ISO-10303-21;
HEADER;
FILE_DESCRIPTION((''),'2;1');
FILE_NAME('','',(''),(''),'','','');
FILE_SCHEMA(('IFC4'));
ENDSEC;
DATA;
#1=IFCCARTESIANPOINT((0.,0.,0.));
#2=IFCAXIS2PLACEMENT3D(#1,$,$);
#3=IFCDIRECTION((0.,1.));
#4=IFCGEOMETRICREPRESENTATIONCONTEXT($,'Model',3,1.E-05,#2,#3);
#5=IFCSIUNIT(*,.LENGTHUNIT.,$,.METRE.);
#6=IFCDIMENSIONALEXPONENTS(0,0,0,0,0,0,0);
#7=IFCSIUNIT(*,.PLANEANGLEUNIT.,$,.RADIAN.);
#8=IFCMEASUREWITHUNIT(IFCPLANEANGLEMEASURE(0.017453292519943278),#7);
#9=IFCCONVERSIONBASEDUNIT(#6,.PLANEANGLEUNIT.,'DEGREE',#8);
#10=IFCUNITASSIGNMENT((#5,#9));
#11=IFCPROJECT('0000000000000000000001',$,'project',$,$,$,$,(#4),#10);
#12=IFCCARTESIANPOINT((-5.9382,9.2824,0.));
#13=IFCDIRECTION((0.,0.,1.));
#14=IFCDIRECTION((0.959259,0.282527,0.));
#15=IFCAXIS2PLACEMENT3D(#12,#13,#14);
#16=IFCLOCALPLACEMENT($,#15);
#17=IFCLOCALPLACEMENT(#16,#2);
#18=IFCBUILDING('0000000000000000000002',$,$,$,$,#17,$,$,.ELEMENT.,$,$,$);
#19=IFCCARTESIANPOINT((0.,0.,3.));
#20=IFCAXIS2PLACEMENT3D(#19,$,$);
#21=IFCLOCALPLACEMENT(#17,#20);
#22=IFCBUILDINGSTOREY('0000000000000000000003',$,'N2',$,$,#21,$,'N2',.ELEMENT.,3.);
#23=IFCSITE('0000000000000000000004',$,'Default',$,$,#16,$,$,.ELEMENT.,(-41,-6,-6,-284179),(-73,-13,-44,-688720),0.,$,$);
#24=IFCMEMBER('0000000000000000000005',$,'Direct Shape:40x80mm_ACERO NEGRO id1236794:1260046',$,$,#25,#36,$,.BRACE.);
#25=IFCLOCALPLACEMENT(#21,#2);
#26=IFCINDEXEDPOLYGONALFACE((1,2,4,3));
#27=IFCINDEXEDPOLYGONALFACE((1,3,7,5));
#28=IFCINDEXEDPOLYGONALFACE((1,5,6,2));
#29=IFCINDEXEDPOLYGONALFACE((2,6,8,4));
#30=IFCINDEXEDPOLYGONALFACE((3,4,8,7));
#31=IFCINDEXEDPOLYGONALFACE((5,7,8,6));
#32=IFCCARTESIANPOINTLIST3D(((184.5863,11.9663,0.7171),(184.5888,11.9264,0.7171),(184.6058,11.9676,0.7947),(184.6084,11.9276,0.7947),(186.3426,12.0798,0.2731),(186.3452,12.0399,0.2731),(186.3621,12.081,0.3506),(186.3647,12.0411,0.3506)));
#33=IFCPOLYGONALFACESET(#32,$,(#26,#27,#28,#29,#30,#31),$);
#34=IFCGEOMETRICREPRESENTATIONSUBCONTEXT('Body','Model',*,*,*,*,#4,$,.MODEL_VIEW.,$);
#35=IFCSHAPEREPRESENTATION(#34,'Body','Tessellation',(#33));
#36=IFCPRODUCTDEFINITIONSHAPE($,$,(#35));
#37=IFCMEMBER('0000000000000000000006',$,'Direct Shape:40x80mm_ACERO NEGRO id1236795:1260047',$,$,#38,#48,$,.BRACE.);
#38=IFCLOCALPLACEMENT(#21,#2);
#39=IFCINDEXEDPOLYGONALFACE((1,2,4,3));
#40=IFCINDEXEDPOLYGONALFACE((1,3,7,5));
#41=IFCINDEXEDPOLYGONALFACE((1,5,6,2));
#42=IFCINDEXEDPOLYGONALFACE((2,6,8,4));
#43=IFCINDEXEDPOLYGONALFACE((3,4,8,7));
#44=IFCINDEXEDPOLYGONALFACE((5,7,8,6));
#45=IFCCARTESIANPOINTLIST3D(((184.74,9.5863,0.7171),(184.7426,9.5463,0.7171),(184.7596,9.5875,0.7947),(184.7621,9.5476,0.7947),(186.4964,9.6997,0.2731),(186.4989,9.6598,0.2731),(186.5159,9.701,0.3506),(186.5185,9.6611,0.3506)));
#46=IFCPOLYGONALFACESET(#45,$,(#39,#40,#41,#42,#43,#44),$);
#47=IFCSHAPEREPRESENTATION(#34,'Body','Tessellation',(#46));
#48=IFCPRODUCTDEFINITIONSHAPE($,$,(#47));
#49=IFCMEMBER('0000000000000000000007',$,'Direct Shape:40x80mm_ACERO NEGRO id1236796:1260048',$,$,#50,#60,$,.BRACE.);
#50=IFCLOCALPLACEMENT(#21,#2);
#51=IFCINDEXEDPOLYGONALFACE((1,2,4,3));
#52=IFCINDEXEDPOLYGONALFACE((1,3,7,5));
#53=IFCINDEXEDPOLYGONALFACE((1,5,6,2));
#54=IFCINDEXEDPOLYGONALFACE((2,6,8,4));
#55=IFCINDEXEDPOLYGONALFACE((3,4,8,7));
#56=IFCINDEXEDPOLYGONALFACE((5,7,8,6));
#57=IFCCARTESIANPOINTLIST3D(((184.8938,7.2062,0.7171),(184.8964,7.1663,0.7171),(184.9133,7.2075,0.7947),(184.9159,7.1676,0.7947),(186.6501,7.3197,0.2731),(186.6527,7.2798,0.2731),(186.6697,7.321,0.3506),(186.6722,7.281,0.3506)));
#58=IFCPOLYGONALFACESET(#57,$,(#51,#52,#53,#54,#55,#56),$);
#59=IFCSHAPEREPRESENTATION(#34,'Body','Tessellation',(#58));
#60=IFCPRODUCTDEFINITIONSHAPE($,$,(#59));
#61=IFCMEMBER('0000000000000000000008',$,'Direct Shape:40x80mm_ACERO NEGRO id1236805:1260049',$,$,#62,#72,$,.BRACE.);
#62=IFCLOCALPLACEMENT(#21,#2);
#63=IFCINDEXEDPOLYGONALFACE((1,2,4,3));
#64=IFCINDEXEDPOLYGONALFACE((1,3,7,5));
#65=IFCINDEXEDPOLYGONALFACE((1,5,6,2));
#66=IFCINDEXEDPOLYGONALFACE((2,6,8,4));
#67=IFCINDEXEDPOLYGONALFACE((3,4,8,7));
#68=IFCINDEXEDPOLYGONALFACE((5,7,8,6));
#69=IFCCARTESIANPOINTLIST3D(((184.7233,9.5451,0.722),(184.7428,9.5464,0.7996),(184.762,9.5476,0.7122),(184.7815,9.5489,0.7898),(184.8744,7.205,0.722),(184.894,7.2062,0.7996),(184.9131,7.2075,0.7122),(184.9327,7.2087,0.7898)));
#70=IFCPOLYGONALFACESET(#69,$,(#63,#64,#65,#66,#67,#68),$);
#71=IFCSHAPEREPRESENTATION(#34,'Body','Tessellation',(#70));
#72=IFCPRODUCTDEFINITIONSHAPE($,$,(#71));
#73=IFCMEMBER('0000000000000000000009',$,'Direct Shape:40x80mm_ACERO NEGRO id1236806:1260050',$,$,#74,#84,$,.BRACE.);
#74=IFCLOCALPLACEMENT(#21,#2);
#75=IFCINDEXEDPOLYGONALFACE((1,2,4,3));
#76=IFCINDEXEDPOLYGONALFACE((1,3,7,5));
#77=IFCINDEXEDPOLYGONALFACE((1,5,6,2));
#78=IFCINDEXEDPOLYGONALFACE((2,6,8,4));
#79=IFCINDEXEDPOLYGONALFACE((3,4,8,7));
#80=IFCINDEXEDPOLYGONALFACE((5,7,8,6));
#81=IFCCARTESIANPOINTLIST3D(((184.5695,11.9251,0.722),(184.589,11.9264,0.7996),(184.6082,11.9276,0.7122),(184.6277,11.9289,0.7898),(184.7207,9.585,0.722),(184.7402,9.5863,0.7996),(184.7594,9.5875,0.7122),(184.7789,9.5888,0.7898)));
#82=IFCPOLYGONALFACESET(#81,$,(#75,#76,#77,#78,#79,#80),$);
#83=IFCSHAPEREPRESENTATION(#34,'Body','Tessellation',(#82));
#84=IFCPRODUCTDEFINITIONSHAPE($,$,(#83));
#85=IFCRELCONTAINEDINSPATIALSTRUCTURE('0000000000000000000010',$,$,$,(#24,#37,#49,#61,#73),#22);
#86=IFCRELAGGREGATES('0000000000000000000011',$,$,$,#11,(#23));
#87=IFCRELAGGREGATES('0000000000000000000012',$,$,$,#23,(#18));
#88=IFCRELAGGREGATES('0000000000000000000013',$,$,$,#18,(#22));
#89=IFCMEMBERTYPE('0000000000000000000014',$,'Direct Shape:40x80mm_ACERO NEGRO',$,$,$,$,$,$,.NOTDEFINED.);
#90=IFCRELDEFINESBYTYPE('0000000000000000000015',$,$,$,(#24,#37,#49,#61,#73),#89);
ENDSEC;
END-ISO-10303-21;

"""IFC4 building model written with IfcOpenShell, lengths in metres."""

from ifc_helpers import new_model, entity, si_unit, converted_unit, direction, frame, frame_2d, origin, place, context, subcontext, project, spatial, rectangle, extrude, type_object, element, save


model = new_model("IFC4")

# Units and contexts
model_context = context("Model", 3, precision=1e-05, world=origin(), true_north=direction((0.0, 1.0)))
body_context = subcontext(model_context, "Body", "Model", "MODEL_VIEW")
ifc_project = project(units=[si_unit("LENGTHUNIT", "METRE"), converted_unit("PLANEANGLEUNIT", "DEGREE", entity("IfcPlaneAngleMeasure", 0.017453292519943278), si_unit("PLANEANGLEUNIT", "RADIAN"), dimensions=[0, 0, 0, 0, 0, 0, 0])], contexts=[model_context])

# Site, building, storey
site_placement = place(None, frame((-5.9382, 9.2824, 0.0), z_axis=(0.0, 0.0, 1.0), x_axis=(0.959259, 0.282527, 0.0)))
site = spatial("IfcSite", under=ifc_project, at=site_placement, Name="Default", CompositionType="ELEMENT", RefLatitude=(-41, -6, -6, -284179), RefLongitude=(-73, -13, -44, -688720), RefElevation=0.0)
building_placement = place(site_placement, origin())
building = spatial("IfcBuilding", under=site, at=building_placement, CompositionType="ELEMENT")
storey_placement = place(building_placement, frame((0.0, 0.0, 3.0)))
storey = spatial("IfcBuildingStorey", under=building, at=storey_placement, Name="N2", LongName="N2", CompositionType="ELEMENT", Elevation=3.0)

# Members
member_type_1 = type_object("IfcMemberType", Name="Direct Shape:40x80mm_ACERO NEGRO", PredefinedType="NOTDEFINED")
member_1_placement = place(storey_placement, origin())
element("IfcMember", 1, at=member_1_placement, inside=storey, type_object=member_type_1, Name="Direct Shape:40x80mm_ACERO NEGRO id1236794:1260046", PredefinedType="BRACE", context=body_context, shape_type="SweptSolid", body=[
    extrude(rectangle(XDim=0.08, YDim=0.04, at=frame_2d((0.0, 0.0), x_axis=(1.0, 0.0))), frame((184.5973, 11.947, 0.7559), z_axis=(0.967595, 0.062512, -0.244649), x_axis=(-0.24414, -0.015773, -0.969612)), (0.0, 0.0, 1.0), 1.8152),
])
member_2_placement = place(storey_placement, origin())
element("IfcMember", 2, at=member_2_placement, inside=storey, type_object=member_type_1, Name="Direct Shape:40x80mm_ACERO NEGRO id1236795:1260047", PredefinedType="BRACE", context=body_context, shape_type="SweptSolid", body=[
    extrude(rectangle(XDim=0.08, YDim=0.04, at=frame_2d((0.0, 0.0), x_axis=(1.0, 0.0))), frame((184.7511, 9.5669, 0.7559), z_axis=(0.967595, 0.062512, -0.244649), x_axis=(-0.24414, -0.015773, -0.969612)), (0.0, 0.0, 1.0), 1.8152),
])
member_3_placement = place(storey_placement, origin())
element("IfcMember", 3, at=member_3_placement, inside=storey, type_object=member_type_1, Name="Direct Shape:40x80mm_ACERO NEGRO id1236796:1260048", PredefinedType="BRACE", context=body_context, shape_type="SweptSolid", body=[
    extrude(rectangle(XDim=0.08, YDim=0.04, at=frame_2d((0.0, 0.0), x_axis=(1.0, 0.0))), frame((184.9048, 7.1869, 0.7559), z_axis=(0.967595, 0.062512, -0.244649), x_axis=(-0.24414, -0.015773, -0.969612)), (0.0, 0.0, 1.0), 1.8152),
])
member_4_placement = place(storey_placement, origin())
element("IfcMember", 4, at=member_4_placement, inside=storey, type_object=member_type_1, Name="Direct Shape:40x80mm_ACERO NEGRO id1236805:1260049", PredefinedType="BRACE", context=body_context, shape_type="SweptSolid", body=[
    extrude(rectangle(XDim=0.08, YDim=0.04, at=frame_2d((0.0, 0.0), x_axis=(0.0, 1.0))), frame((184.9036, 7.2069, 0.7559), z_axis=(-0.064471, 0.99792, 0.0), x_axis=(0.967595, 0.062512, -0.244649)), (0.0, 0.0, 1.0), 2.345),
])
member_5_placement = place(storey_placement, origin())
element("IfcMember", 5, at=member_5_placement, inside=storey, type_object=member_type_1, Name="Direct Shape:40x80mm_ACERO NEGRO id1236806:1260050", PredefinedType="BRACE", context=body_context, shape_type="SweptSolid", body=[
    extrude(rectangle(XDim=0.08, YDim=0.04, at=frame_2d((0.0, 0.0), x_axis=(0.0, 1.0))), frame((184.7498, 9.5869, 0.7559), z_axis=(-0.064471, 0.99792, 0.0), x_axis=(0.967595, 0.062512, -0.244649)), (0.0, 0.0, 1.0), 2.345),
])

save(model, "model.ifc")
